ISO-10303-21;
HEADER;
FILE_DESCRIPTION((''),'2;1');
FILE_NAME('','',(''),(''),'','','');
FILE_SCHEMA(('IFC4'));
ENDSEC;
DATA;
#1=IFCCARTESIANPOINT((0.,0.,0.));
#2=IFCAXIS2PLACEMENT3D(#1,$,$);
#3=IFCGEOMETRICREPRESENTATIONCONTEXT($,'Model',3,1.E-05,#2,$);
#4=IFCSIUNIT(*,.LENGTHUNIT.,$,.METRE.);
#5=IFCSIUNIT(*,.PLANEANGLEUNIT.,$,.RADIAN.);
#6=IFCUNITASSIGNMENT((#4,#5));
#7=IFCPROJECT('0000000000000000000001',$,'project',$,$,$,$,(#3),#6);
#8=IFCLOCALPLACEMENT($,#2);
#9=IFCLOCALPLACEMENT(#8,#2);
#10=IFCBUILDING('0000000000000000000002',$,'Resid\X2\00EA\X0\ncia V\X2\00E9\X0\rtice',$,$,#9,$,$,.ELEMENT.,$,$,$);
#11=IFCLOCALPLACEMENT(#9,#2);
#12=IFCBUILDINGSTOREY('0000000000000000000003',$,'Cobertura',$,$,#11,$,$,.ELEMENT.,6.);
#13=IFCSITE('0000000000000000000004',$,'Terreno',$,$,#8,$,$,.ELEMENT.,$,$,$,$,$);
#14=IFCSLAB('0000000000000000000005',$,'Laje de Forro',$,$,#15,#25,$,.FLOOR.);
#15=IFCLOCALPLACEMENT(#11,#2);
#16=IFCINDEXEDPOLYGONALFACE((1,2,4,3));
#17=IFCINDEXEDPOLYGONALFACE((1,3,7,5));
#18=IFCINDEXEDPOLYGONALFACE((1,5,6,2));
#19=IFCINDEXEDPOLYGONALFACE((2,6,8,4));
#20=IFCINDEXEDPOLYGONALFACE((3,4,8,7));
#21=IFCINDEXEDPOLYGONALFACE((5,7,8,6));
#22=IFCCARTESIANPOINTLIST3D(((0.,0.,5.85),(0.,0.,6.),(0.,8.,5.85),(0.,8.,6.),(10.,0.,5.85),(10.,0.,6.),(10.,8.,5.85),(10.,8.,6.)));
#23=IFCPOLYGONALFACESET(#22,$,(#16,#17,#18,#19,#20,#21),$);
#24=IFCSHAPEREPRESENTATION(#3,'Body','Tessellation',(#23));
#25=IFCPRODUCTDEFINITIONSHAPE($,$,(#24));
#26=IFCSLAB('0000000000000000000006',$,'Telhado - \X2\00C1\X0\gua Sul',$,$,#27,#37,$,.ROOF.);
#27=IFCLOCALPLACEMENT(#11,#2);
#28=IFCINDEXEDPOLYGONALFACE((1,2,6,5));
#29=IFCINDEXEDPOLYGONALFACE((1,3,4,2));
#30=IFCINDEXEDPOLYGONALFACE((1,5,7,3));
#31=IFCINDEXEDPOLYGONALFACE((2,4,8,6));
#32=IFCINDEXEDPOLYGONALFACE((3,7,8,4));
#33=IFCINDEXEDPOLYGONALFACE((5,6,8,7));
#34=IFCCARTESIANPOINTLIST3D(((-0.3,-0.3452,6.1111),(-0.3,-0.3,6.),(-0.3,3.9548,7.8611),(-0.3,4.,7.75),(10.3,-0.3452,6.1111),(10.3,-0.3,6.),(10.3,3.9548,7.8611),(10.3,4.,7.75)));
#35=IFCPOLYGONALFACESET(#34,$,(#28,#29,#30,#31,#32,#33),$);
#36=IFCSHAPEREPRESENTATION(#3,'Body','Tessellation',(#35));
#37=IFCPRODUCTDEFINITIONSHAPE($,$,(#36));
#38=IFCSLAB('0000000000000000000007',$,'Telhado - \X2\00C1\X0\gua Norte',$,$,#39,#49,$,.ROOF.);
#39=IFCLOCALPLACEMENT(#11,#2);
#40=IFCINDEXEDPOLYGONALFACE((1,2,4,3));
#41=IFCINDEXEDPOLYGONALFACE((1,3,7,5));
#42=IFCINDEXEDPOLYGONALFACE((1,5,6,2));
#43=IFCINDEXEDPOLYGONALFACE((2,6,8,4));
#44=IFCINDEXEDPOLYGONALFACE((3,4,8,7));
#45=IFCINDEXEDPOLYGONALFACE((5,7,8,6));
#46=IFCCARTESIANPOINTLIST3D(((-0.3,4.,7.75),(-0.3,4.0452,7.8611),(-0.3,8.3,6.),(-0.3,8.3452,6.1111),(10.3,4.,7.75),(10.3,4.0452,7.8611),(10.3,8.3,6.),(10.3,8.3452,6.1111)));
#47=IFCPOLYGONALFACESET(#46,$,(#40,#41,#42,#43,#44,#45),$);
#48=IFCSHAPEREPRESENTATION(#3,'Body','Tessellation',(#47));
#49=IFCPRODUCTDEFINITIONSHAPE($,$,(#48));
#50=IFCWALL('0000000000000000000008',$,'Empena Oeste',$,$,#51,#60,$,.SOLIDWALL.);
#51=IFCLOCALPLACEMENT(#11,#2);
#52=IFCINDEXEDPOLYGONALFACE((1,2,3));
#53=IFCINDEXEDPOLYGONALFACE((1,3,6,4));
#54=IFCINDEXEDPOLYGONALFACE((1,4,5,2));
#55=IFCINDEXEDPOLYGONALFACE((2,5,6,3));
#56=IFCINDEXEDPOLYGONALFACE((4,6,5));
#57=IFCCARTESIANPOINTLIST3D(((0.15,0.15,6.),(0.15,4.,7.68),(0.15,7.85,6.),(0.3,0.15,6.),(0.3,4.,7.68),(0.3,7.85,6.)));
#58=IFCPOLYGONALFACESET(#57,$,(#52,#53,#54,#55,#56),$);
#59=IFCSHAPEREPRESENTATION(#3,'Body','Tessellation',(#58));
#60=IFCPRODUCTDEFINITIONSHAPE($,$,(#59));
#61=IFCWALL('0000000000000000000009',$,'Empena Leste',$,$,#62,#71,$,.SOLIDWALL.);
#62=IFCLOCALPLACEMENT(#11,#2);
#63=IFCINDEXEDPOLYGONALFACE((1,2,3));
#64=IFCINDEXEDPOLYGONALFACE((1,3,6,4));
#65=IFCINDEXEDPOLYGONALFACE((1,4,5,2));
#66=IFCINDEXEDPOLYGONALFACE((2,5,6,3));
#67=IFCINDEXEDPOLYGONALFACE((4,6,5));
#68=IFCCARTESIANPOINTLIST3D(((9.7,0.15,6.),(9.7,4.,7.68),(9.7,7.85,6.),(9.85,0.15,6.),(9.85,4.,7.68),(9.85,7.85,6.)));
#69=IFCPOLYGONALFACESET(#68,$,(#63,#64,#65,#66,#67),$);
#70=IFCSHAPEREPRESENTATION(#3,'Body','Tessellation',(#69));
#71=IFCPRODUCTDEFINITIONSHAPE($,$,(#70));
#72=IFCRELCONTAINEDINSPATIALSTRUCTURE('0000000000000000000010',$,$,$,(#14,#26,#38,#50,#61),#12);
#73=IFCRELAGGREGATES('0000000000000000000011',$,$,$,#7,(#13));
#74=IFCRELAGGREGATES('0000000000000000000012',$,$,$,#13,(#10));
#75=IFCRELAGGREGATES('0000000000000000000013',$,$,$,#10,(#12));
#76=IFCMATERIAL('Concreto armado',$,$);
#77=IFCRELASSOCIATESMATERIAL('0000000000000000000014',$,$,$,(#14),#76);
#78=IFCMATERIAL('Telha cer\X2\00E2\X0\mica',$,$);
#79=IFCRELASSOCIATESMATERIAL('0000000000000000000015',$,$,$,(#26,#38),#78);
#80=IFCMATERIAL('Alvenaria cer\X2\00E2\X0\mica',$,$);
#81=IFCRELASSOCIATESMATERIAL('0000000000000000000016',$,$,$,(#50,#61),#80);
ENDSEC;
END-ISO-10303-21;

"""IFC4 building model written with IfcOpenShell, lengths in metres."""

from ifc_helpers import new_model, si_unit, frame, frame_2d, origin, place, context, project, spatial, polyline, rectangle, outline, extrude, material, element, save


model = new_model("IFC4")

# Units and contexts
model_context = context("Model", 3, precision=1e-05, world=origin())
ifc_project = project(units=[si_unit("LENGTHUNIT", "METRE"), si_unit("PLANEANGLEUNIT", "RADIAN")], contexts=[model_context])

# Site, building, storey
site_placement = place(None, origin())
site = spatial("IfcSite", under=ifc_project, at=site_placement, Name="Terreno", CompositionType="ELEMENT")
building_placement = place(site_placement, origin())
building = spatial("IfcBuilding", under=site, at=building_placement, Name="Residência Vértice", CompositionType="ELEMENT")
storey_placement = place(building_placement, origin())
storey = spatial("IfcBuildingStorey", under=building, at=storey_placement, Name="Cobertura", CompositionType="ELEMENT", Elevation=6.0)

# Slabs
ifc_material_1 = material(Name="Concreto armado")
slab_1_placement = place(storey_placement, origin())
element("IfcSlab", 1, at=slab_1_placement, inside=storey, material=ifc_material_1, Name="Laje de Forro", PredefinedType="FLOOR", context=model_context, shape_type="SweptSolid", body=[
    extrude(rectangle(XDim=10.0, YDim=8.0, at=frame_2d((5.0, 4.0))), frame((0.0, 0.0, 5.85)), (0.0, 0.0, 1.0), 0.15),
])
ifc_material_2 = material(Name="Telha cerâmica")
slab_2_placement = place(storey_placement, origin())
element("IfcSlab", 2, at=slab_2_placement, inside=storey, material=ifc_material_2, Name="Telhado - Água Sul", PredefinedType="ROOF", context=model_context, shape_type="SweptSolid", body=[
    extrude(rectangle(XDim=10.6, YDim=4.6425, at=frame_2d((5.3, 2.3212))), frame((-0.3, -0.3, 6.0), z_axis=(0.0, -0.37695, 0.92623), x_axis=(1.0, 0.0, 0.0)), (0.0, 0.0, 1.0), 0.12),
])
slab_3_placement = place(storey_placement, origin())
element("IfcSlab", 3, at=slab_3_placement, inside=storey, material=ifc_material_2, Name="Telhado - Água Norte", PredefinedType="ROOF", context=model_context, shape_type="SweptSolid", body=[
    extrude(rectangle(XDim=10.6, YDim=4.6425, at=frame_2d((5.3, 2.3212))), frame((10.3, 8.3, 6.0), z_axis=(0.0, 0.37695, 0.92623), x_axis=(-1.0, 0.0, 0.0)), (0.0, 0.0, 1.0), 0.12),
])

# Walls
ifc_material_3 = material(Name="Alvenaria cerâmica")
wall_1_placement = place(storey_placement, origin())
element("IfcWall", 4, at=wall_1_placement, inside=storey, material=ifc_material_3, Name="Empena Oeste", PredefinedType="SOLIDWALL", context=model_context, shape_type="SweptSolid", body=[
    extrude(outline(polyline([(0.15, 0.0), (7.85, 0.0), (4.0, 1.68), (0.15, 0.0)])), frame((0.15, 0.0, 6.0), z_axis=(1.0, 0.0, 0.0), x_axis=(0.0, 1.0, 0.0)), (0.0, 0.0, 1.0), 0.15),
])
wall_2_placement = place(storey_placement, origin())
element("IfcWall", 5, at=wall_2_placement, inside=storey, material=ifc_material_3, Name="Empena Leste", PredefinedType="SOLIDWALL", context=model_context, shape_type="SweptSolid", body=[
    extrude(outline(polyline([(0.15, 0.0), (7.85, 0.0), (4.0, 1.68), (0.15, 0.0)])), frame((9.7, 0.0, 6.0), z_axis=(1.0, 0.0, 0.0), x_axis=(0.0, 1.0, 0.0)), (0.0, 0.0, 1.0), 0.15),
])

save(model, "model.ifc")
